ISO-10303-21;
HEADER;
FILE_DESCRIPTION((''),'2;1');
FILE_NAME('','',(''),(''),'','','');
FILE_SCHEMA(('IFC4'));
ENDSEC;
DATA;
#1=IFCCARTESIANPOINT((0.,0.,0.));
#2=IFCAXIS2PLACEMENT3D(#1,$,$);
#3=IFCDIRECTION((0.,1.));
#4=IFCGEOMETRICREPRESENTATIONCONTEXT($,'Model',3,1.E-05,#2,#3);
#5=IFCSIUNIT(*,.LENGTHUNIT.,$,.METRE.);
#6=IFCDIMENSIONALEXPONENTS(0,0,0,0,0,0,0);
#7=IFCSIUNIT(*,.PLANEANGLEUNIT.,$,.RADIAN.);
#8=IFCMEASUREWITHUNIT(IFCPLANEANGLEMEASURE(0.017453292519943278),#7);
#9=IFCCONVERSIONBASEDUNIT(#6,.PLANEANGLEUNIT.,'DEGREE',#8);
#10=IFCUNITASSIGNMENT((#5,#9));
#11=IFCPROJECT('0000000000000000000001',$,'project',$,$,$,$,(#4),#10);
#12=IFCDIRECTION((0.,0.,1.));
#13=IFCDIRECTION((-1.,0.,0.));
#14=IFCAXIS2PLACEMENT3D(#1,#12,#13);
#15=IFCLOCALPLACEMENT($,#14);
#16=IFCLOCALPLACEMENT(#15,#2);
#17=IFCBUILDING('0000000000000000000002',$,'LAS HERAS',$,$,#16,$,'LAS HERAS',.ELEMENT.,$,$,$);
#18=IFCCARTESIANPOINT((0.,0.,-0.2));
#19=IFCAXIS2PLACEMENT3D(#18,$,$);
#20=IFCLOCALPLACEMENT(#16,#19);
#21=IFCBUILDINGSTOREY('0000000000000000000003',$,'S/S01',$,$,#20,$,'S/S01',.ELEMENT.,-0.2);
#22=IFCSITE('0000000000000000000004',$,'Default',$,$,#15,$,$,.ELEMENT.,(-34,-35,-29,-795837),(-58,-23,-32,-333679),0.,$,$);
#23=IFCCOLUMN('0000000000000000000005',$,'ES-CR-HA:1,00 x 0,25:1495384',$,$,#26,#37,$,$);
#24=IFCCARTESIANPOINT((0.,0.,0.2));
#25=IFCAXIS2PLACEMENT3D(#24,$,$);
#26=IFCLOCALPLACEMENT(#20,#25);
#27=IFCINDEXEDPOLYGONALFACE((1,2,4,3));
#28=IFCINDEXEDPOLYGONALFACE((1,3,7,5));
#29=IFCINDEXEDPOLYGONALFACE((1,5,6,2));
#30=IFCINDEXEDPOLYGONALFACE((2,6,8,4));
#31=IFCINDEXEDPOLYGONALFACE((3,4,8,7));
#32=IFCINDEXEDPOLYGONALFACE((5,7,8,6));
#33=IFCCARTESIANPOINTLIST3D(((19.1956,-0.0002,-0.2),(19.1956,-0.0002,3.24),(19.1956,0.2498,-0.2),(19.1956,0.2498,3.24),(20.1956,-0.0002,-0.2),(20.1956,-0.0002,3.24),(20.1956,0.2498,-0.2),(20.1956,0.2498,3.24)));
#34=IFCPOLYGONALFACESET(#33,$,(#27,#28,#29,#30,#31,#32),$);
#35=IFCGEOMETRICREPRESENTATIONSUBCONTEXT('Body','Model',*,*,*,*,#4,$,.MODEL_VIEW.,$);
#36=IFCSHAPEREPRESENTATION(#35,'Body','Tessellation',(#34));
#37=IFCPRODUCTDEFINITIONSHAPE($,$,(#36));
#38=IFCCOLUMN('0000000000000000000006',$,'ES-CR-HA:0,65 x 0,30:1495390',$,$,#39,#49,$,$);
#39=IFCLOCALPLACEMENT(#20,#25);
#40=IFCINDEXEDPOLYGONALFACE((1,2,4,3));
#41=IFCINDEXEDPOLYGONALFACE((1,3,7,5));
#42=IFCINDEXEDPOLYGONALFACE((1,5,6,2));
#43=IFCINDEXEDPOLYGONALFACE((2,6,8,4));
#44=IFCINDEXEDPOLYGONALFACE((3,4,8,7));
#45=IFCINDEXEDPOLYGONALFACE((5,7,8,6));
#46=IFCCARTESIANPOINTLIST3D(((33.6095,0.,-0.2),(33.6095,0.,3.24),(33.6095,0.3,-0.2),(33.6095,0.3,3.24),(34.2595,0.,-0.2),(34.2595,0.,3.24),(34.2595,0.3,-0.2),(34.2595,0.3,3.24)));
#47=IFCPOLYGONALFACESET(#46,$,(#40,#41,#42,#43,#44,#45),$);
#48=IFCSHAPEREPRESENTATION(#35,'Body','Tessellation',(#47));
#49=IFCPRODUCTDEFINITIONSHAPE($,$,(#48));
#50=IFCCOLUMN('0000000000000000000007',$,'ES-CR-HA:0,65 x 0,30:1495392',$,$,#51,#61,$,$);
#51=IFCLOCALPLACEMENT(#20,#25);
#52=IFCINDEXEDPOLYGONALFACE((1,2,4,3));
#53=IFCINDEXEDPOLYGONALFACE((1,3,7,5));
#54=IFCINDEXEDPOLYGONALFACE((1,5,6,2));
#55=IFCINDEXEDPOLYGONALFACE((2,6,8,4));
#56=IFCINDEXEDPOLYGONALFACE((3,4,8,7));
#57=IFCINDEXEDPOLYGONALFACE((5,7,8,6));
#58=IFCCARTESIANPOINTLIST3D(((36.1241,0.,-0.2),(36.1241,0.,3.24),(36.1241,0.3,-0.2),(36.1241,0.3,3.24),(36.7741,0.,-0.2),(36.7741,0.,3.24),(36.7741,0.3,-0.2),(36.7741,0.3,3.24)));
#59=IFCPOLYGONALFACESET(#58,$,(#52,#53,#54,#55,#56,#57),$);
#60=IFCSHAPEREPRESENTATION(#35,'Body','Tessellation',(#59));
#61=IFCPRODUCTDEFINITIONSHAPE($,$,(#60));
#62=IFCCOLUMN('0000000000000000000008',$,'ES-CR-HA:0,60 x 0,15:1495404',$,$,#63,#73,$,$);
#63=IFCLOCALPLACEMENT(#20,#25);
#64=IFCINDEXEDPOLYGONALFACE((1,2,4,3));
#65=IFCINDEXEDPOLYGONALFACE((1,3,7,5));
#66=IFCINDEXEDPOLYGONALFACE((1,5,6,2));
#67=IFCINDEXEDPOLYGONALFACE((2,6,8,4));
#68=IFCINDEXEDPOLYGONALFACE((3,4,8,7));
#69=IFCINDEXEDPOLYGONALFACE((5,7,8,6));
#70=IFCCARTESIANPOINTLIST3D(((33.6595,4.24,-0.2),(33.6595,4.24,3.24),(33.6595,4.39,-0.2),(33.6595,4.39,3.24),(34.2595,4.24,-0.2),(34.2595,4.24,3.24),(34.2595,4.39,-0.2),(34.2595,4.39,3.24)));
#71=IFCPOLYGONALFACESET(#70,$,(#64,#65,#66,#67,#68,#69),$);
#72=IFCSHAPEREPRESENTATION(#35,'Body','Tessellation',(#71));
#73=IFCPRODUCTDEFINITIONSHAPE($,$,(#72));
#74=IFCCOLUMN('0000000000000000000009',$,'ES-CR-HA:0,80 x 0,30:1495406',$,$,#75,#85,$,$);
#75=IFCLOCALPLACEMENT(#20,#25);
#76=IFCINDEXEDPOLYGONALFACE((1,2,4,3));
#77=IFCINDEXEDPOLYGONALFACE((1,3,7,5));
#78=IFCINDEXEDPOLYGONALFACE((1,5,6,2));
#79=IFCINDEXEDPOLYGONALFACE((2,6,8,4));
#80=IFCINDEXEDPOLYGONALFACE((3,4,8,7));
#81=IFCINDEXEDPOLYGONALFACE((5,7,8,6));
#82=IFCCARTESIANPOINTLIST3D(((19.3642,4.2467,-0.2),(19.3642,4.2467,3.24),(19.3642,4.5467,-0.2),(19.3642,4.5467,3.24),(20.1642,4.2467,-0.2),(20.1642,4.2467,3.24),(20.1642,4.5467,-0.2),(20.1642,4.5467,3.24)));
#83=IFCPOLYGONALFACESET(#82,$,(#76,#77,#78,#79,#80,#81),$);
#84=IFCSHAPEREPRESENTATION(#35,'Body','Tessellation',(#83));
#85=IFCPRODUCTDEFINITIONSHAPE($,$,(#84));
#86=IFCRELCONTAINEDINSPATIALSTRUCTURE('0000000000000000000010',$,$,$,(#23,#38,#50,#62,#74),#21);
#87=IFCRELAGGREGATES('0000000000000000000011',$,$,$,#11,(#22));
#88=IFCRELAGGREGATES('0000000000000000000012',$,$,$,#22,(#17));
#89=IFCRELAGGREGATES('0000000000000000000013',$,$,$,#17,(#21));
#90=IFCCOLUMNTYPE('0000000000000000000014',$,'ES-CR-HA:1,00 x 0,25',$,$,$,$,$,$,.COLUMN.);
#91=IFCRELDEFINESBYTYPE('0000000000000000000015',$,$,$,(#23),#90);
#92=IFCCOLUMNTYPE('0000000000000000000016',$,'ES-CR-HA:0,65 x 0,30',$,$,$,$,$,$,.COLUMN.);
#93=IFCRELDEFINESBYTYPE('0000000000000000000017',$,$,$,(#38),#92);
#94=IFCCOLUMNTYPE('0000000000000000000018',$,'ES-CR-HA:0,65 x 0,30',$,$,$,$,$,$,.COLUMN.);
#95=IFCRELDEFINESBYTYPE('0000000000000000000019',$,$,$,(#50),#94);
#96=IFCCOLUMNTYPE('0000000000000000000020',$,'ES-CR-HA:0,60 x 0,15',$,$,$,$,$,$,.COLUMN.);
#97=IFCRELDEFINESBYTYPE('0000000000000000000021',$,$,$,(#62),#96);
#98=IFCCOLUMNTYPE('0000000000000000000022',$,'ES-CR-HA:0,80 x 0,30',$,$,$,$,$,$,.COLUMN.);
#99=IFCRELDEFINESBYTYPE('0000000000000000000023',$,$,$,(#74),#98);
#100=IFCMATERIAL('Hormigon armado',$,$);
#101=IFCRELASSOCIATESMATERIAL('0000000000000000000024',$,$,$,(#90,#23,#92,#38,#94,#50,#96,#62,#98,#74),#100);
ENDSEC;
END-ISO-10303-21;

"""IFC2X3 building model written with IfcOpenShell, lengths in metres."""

from ifc_helpers import new_model, entity, si_unit, converted_unit, direction, frame, frame_2d, origin, origin_2d_with_axis, place, context, subcontext, project, spatial, rectangle, extrude, source, transform, mapped, material, type_object, type_shapes, element, save


model = new_model("IFC2X3")

# Units and contexts
model_context = context("Model", 3, precision=1e-05, world=origin(), true_north=direction((0.0, 1.0)))
body_context = subcontext(model_context, "Body", "Model", "MODEL_VIEW")
ifc_project = project(units=[si_unit("LENGTHUNIT", "METRE"), converted_unit("PLANEANGLEUNIT", "DEGREE", entity("IfcPlaneAngleMeasure", 0.017453292519943278), si_unit("PLANEANGLEUNIT", "RADIAN"), dimensions=[0, 0, 0, 0, 0, 0, 0])], contexts=[model_context])

# Site, building, storey
site_placement = place(None, frame((0.0, 0.0, 0.0), z_axis=(0.0, 0.0, 1.0), x_axis=(-1.0, 0.0, 0.0)))
site = spatial("IfcSite", under=ifc_project, at=site_placement, Name="Default", CompositionType="ELEMENT", RefLatitude=(-34, -35, -29, -795837), RefLongitude=(-58, -23, -32, -333679), RefElevation=0.0)
building_placement = place(site_placement, origin())
building = spatial("IfcBuilding", under=site, at=building_placement, Name="LAS HERAS", LongName="LAS HERAS", CompositionType="ELEMENT")
storey_placement = place(building_placement, frame((0.0, 0.0, -0.2)))
storey = spatial("IfcBuildingStorey", under=building, at=storey_placement, Name="S/S01", LongName="S/S01", CompositionType="ELEMENT", Elevation=-0.2)

# Columns
ifc_material = material(Name="Hormigon armado")
column_type_1 = type_object("IfcColumnType", Name="ES-CR-HA:1,00 x 0,25", PredefinedType="COLUMN", material=ifc_material)
shared_shape_1 = source(origin(), body_context, "Body", "SweptSolid", [
    extrude(rectangle(XDim=1.0, YDim=0.25, at=origin_2d_with_axis()), frame((19.6956, 0.1248, -0.2), z_axis=(0.0, 0.0, 1.0), x_axis=(-1.0, 0.0, 0.0)), (0.0, 0.0, 1.0), 3.44),
])
type_shapes(column_type_1, [shared_shape_1])
column_1_placement = place(storey_placement, frame((0.0, 0.0, 0.2)))
element("IfcColumn", 1, at=column_1_placement, inside=storey, type_object=column_type_1, material=ifc_material, Name="ES-CR-HA:1,00 x 0,25:1495384", context=body_context, shape_type="MappedRepresentation", body=[
    mapped(shared_shape_1, transform((0.0, 0.0, 0.0), scale=1.0)),
])
column_type_2 = type_object("IfcColumnType", Name="ES-CR-HA:0,65 x 0,30", PredefinedType="COLUMN", material=ifc_material)
shared_shape_2 = source(origin(), body_context, "Body", "SweptSolid", [
    extrude(rectangle(XDim=0.65, YDim=0.3, at=origin_2d_with_axis()), frame((33.9345, 0.15, -0.2), z_axis=(0.0, 0.0, 1.0), x_axis=(-1.0, 0.0, 0.0)), (0.0, 0.0, 1.0), 3.44),
])
type_shapes(column_type_2, [shared_shape_2])
column_2_placement = place(storey_placement, frame((0.0, 0.0, 0.2)))
element("IfcColumn", 2, at=column_2_placement, inside=storey, type_object=column_type_2, material=ifc_material, Name="ES-CR-HA:0,65 x 0,30:1495390", context=body_context, shape_type="MappedRepresentation", body=[
    mapped(shared_shape_2, transform((0.0, 0.0, 0.0), scale=1.0)),
])
column_type_3 = type_object("IfcColumnType", Name="ES-CR-HA:0,65 x 0,30", PredefinedType="COLUMN", material=ifc_material)
shared_shape_3 = source(origin(), body_context, "Body", "SweptSolid", [
    extrude(rectangle(XDim=0.65, YDim=0.3, at=origin_2d_with_axis()), frame((36.4491, 0.15, -0.2), z_axis=(0.0, 0.0, 1.0), x_axis=(-1.0, 0.0, 0.0)), (0.0, 0.0, 1.0), 3.44),
])
type_shapes(column_type_3, [shared_shape_3])
column_3_placement = place(storey_placement, frame((0.0, 0.0, 0.2)))
element("IfcColumn", 3, at=column_3_placement, inside=storey, type_object=column_type_3, material=ifc_material, Name="ES-CR-HA:0,65 x 0,30:1495392", context=body_context, shape_type="MappedRepresentation", body=[
    mapped(shared_shape_3, transform((0.0, 0.0, 0.0), scale=1.0)),
])
column_type_4 = type_object("IfcColumnType", Name="ES-CR-HA:0,60 x 0,15", PredefinedType="COLUMN", material=ifc_material)
shared_shape_4 = source(origin(), body_context, "Body", "SweptSolid", [
    extrude(rectangle(XDim=0.6, YDim=0.15, at=frame_2d((0.0, 0.0), x_axis=(1.0, 0.0))), frame((33.9595, 4.315, -0.2), z_axis=(0.0, 0.0, 1.0), x_axis=(-1.0, 0.0, 0.0)), (0.0, 0.0, 1.0), 3.44),
])
type_shapes(column_type_4, [shared_shape_4])
column_4_placement = place(storey_placement, frame((0.0, 0.0, 0.2)))
element("IfcColumn", 4, at=column_4_placement, inside=storey, type_object=column_type_4, material=ifc_material, Name="ES-CR-HA:0,60 x 0,15:1495404", context=body_context, shape_type="MappedRepresentation", body=[
    mapped(shared_shape_4, transform((0.0, 0.0, 0.0), scale=1.0)),
])
column_type_5 = type_object("IfcColumnType", Name="ES-CR-HA:0,80 x 0,30", PredefinedType="COLUMN", material=ifc_material)
shared_shape_5 = source(origin(), body_context, "Body", "SweptSolid", [
    extrude(rectangle(XDim=0.8, YDim=0.3, at=origin_2d_with_axis()), frame((19.7642, 4.3967, -0.2), z_axis=(0.0, 0.0, 1.0), x_axis=(-1.0, 0.0, 0.0)), (0.0, 0.0, 1.0), 3.44),
])
type_shapes(column_type_5, [shared_shape_5])
column_5_placement = place(storey_placement, frame((0.0, 0.0, 0.2)))
element("IfcColumn", 5, at=column_5_placement, inside=storey, type_object=column_type_5, material=ifc_material, Name="ES-CR-HA:0,80 x 0,30:1495406", context=body_context, shape_type="MappedRepresentation", body=[
    mapped(shared_shape_5, transform((0.0, 0.0, 0.0), scale=1.0)),
])

save(model, "model.ifc")
